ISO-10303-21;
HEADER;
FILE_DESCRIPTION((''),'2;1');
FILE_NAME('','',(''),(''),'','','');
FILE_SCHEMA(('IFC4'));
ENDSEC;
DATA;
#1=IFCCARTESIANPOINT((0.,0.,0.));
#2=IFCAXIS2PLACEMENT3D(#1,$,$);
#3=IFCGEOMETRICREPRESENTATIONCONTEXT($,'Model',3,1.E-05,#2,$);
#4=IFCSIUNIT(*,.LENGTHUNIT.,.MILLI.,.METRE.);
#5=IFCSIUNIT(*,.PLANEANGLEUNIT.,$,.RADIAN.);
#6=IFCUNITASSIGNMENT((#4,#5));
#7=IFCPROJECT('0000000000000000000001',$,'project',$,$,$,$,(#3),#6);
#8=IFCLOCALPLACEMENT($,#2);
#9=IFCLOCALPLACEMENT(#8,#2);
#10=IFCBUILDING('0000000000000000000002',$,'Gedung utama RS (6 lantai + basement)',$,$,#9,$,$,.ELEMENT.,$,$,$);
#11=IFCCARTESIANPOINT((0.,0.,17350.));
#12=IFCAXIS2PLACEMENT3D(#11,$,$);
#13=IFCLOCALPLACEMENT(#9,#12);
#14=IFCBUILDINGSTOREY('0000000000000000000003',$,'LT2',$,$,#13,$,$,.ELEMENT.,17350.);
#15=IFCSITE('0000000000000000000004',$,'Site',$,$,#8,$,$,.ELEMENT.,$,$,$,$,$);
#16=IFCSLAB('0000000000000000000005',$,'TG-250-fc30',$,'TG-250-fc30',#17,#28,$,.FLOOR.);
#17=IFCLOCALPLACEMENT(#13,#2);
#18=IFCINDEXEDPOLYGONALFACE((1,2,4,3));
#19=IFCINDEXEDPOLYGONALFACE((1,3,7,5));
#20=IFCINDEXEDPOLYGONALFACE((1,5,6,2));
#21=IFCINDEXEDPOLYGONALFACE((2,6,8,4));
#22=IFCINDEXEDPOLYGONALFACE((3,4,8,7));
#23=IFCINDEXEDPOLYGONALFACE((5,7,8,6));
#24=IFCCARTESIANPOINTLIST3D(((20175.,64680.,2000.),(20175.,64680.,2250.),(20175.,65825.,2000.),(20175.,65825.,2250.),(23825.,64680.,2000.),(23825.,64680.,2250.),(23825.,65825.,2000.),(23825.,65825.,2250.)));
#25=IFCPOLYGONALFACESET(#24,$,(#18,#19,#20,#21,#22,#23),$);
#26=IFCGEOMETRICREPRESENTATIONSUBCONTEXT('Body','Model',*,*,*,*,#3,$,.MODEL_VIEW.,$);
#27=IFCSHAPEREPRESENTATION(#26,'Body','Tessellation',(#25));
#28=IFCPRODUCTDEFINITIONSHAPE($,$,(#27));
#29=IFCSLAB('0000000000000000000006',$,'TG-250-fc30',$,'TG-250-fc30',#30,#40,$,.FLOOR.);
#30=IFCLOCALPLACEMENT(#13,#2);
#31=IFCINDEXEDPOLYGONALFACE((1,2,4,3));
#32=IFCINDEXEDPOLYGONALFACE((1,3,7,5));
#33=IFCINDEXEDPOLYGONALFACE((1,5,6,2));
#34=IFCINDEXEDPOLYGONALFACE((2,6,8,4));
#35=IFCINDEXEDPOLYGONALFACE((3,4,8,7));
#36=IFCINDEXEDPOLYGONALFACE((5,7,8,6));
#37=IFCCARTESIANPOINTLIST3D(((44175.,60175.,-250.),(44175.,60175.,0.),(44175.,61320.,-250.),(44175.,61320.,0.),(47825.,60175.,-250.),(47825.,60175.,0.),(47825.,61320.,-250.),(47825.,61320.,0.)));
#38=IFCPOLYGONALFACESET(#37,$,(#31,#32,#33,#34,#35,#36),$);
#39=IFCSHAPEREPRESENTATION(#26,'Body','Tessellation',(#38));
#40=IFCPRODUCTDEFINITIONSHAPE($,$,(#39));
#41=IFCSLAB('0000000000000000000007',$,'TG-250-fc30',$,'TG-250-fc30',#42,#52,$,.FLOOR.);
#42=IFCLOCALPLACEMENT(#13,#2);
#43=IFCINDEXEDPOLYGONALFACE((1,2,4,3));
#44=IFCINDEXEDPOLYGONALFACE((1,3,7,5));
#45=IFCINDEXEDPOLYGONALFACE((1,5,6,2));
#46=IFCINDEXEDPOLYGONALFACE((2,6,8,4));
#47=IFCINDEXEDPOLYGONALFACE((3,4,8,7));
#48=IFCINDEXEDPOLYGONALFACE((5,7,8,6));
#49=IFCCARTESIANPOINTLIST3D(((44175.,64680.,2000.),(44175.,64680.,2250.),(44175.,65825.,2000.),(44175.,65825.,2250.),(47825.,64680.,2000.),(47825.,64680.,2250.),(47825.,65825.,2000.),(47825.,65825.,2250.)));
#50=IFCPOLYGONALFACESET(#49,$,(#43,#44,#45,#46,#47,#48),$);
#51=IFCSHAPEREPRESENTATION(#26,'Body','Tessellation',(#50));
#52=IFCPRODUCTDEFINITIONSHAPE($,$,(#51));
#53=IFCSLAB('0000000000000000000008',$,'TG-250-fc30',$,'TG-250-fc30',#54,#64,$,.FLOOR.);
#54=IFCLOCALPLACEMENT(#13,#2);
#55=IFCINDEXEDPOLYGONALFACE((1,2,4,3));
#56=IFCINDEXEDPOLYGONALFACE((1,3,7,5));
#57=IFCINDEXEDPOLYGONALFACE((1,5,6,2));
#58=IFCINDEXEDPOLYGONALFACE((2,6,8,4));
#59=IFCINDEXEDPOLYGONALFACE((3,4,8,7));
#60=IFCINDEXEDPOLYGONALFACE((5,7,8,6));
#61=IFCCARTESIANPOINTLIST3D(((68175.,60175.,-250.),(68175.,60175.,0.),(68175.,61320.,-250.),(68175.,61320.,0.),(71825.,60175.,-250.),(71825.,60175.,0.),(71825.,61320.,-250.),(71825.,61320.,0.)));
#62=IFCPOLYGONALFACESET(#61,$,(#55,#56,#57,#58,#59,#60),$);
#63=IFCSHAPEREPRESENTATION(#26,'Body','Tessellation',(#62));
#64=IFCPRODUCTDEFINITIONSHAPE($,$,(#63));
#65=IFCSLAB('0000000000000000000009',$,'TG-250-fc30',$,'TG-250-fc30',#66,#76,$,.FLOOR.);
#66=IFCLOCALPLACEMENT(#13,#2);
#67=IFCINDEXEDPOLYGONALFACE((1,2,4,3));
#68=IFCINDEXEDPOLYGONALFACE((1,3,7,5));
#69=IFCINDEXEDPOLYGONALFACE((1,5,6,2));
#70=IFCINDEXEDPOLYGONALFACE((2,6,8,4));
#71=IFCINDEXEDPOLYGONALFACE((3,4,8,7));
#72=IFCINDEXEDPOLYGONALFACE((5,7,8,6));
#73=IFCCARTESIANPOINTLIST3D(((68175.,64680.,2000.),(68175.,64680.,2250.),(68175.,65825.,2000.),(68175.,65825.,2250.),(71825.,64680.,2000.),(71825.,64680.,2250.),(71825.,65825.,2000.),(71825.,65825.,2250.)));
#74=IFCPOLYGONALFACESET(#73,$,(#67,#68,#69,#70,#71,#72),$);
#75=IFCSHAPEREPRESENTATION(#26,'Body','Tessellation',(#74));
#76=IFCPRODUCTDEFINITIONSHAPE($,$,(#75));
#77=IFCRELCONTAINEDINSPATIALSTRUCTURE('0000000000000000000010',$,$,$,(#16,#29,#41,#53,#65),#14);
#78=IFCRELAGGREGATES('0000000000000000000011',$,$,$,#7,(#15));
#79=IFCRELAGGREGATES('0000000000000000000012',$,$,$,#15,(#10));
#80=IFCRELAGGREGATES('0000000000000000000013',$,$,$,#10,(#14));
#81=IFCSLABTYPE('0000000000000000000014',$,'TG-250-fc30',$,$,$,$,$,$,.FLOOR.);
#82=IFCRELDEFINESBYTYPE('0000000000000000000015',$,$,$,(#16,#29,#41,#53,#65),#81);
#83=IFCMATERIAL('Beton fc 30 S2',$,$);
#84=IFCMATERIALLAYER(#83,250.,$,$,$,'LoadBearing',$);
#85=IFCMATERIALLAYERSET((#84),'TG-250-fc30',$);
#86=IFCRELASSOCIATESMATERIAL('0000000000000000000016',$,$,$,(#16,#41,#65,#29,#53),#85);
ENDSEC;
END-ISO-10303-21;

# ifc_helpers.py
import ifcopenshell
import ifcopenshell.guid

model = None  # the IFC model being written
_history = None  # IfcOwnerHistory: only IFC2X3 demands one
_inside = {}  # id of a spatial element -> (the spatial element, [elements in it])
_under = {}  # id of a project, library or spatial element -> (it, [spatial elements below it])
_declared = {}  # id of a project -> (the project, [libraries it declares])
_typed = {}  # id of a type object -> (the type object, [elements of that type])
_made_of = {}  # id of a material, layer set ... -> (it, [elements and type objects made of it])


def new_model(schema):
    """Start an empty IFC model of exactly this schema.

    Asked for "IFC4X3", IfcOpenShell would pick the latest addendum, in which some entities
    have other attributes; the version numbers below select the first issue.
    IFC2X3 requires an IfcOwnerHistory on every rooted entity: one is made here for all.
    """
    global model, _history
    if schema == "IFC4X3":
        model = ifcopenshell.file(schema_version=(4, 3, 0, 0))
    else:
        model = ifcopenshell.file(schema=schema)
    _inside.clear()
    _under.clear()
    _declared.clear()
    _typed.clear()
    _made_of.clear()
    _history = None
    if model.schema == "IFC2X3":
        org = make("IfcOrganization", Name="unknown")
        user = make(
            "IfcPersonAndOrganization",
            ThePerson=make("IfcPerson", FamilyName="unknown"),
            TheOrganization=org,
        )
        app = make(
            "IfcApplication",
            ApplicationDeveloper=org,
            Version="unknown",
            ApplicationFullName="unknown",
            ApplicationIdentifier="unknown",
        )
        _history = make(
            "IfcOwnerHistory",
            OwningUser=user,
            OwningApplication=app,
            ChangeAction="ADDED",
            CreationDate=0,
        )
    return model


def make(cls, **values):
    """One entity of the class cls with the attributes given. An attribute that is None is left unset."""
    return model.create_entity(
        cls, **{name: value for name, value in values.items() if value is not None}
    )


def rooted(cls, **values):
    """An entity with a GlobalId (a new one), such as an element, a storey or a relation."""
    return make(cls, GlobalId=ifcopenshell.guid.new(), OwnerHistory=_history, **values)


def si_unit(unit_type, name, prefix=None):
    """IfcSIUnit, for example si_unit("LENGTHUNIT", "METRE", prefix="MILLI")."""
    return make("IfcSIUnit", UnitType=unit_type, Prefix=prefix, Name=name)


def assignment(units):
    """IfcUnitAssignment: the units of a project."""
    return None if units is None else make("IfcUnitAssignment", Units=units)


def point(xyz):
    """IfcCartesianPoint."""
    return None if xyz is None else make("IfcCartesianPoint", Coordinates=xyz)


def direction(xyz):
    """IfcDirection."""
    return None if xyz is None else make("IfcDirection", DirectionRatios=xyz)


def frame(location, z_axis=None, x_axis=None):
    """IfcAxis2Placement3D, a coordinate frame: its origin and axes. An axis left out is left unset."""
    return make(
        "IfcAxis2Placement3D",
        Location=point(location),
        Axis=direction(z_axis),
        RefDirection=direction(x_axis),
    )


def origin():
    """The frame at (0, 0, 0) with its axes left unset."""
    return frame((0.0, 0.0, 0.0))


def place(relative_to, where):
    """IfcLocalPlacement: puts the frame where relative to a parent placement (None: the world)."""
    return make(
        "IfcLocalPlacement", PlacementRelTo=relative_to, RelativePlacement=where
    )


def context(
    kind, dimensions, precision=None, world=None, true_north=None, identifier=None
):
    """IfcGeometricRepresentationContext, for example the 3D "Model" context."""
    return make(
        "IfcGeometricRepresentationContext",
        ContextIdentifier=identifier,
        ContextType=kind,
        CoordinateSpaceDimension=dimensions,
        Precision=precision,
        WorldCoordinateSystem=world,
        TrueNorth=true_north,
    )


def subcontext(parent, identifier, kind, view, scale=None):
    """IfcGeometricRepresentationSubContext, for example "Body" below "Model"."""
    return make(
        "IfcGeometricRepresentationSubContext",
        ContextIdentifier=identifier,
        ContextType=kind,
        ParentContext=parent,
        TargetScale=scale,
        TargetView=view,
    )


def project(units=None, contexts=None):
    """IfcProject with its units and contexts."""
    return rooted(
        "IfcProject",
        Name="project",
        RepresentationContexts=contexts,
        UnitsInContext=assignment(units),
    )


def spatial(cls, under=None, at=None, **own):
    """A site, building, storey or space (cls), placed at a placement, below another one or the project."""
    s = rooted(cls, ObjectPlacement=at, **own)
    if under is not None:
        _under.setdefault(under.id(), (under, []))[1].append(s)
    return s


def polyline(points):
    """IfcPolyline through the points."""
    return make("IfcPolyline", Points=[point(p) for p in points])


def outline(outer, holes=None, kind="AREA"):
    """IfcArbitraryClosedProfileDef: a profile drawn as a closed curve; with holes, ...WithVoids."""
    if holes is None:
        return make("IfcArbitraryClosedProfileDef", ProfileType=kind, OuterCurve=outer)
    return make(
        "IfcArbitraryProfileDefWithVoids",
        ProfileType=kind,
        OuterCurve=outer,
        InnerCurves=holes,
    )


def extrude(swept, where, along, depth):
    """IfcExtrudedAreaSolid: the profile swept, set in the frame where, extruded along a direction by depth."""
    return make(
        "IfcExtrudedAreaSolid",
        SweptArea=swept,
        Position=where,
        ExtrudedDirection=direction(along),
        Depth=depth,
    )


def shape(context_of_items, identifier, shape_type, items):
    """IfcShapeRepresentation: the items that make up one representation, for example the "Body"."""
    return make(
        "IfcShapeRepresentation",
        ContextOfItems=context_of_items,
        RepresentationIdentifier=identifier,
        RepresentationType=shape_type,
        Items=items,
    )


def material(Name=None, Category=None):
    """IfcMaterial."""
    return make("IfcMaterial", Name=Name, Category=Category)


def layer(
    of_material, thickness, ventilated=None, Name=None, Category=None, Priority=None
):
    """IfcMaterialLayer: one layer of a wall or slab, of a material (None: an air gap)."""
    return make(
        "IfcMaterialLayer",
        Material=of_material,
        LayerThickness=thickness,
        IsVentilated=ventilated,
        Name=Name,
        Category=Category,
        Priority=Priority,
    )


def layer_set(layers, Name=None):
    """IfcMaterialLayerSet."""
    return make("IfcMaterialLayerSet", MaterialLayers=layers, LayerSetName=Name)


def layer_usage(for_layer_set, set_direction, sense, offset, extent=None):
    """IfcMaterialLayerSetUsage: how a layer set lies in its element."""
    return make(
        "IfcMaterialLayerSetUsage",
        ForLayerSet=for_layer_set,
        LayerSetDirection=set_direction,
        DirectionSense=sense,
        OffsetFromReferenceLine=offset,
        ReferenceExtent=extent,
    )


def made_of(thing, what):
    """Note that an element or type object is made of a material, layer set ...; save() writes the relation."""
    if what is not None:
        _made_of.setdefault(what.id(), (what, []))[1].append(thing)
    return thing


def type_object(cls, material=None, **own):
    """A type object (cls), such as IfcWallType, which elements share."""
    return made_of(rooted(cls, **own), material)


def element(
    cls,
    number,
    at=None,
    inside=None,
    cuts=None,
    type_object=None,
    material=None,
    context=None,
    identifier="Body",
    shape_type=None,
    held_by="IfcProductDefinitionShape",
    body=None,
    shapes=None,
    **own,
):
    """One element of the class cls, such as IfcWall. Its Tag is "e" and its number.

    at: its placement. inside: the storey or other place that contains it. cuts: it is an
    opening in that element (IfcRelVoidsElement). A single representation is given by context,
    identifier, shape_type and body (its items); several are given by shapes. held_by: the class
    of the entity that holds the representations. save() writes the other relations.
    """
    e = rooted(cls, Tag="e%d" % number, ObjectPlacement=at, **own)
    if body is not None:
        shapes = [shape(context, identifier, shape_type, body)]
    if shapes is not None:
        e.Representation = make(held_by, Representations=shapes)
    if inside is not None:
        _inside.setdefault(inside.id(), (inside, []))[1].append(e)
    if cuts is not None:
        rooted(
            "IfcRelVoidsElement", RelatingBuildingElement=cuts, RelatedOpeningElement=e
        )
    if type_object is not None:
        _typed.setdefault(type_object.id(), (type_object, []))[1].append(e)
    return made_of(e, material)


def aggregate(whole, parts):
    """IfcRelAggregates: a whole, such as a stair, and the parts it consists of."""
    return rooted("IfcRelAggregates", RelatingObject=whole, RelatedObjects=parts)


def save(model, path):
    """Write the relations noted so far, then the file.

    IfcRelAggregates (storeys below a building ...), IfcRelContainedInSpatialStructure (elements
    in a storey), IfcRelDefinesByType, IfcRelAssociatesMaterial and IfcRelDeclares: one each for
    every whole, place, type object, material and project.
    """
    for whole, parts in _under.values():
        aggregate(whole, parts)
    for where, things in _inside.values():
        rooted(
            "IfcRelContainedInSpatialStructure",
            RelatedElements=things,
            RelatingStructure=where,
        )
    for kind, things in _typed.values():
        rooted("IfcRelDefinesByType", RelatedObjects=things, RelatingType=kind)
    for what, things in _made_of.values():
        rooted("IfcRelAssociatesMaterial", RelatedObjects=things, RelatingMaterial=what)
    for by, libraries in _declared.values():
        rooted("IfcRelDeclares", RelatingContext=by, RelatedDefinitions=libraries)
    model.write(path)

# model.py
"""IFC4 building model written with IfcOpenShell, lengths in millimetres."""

from ifc_helpers import new_model, si_unit, frame, origin, place, context, subcontext, project, spatial, polyline, outline, extrude, material, layer, layer_set, layer_usage, type_object, element, save


model = new_model("IFC4")

# Units and contexts
model_context = context("Model", 3, precision=1e-05, world=origin())
body_context = subcontext(model_context, "Body", "Model", "MODEL_VIEW")
ifc_project = project(units=[si_unit("LENGTHUNIT", "METRE", prefix="MILLI"), si_unit("PLANEANGLEUNIT", "RADIAN")], contexts=[model_context])

# Site, building, storey
site_placement = place(None, origin())
site = spatial("IfcSite", under=ifc_project, at=site_placement, Name="Site", CompositionType="ELEMENT")
building_placement = place(site_placement, origin())
building = spatial("IfcBuilding", under=site, at=building_placement, Name="Gedung utama RS (6 lantai + basement)", CompositionType="ELEMENT")
storey_placement = place(building_placement, frame((0.0, 0.0, 17350.0)))
storey = spatial("IfcBuildingStorey", under=building, at=storey_placement, Name="LT2", CompositionType="ELEMENT", Elevation=17350.0)

# Shared definitions
ifc_material = material(Name="Beton fc 30 S2")

# Slabs
ifc_layer_1 = layer(ifc_material, 250.0, Category="LoadBearing")
ifc_layer_set_1 = layer_set([ifc_layer_1], Name="TG-250-fc30")
ifc_layer_usage_1 = layer_usage(ifc_layer_set_1, "AXIS3", "NEGATIVE", 0.0)
slab_type_1 = type_object("IfcSlabType", Name="TG-250-fc30", PredefinedType="FLOOR")
ifc_layer_usage_2 = layer_usage(ifc_layer_set_1, "AXIS3", "NEGATIVE", 2250.0)
slab_1_placement = place(storey_placement, origin())
element("IfcSlab", 1, at=slab_1_placement, inside=storey, type_object=slab_type_1, material=ifc_layer_usage_2, Name="TG-250-fc30", ObjectType="TG-250-fc30", PredefinedType="FLOOR", context=body_context, shape_type="SweptSolid", body=[
    extrude(outline(polyline([(23825.0, 64680.0), (23825.0, 65825.0), (20175.0, 65825.0), (20175.0, 64680.0), (23825.0, 64680.0)])), frame((0.0, 0.0, 2000.0)), (0.0, 0.0, 1.0), 250.0),
])
slab_2_placement = place(storey_placement, origin())
element("IfcSlab", 2, at=slab_2_placement, inside=storey, type_object=slab_type_1, material=ifc_layer_usage_1, Name="TG-250-fc30", ObjectType="TG-250-fc30", PredefinedType="FLOOR", context=body_context, shape_type="SweptSolid", body=[
    extrude(outline(polyline([(47825.0, 60175.0), (47825.0, 61320.0), (44175.0, 61320.0), (44175.0, 60175.0), (47825.0, 60175.0)])), frame((0.0, 0.0, -250.0)), (0.0, 0.0, 1.0), 250.0),
])
slab_3_placement = place(storey_placement, origin())
element("IfcSlab", 3, at=slab_3_placement, inside=storey, type_object=slab_type_1, material=ifc_layer_usage_2, Name="TG-250-fc30", ObjectType="TG-250-fc30", PredefinedType="FLOOR", context=body_context, shape_type="SweptSolid", body=[
    extrude(outline(polyline([(47825.0, 64680.0), (47825.0, 65825.0), (44175.0, 65825.0), (44175.0, 64680.0), (47825.0, 64680.0)])), frame((0.0, 0.0, 2000.0)), (0.0, 0.0, 1.0), 250.0),
])
slab_4_placement = place(storey_placement, origin())
element("IfcSlab", 4, at=slab_4_placement, inside=storey, type_object=slab_type_1, material=ifc_layer_usage_1, Name="TG-250-fc30", ObjectType="TG-250-fc30", PredefinedType="FLOOR", context=body_context, shape_type="SweptSolid", body=[
    extrude(outline(polyline([(71825.0, 60175.0), (71825.0, 61320.0), (68175.0, 61320.0), (68175.0, 60175.0), (71825.0, 60175.0)])), frame((0.0, 0.0, -250.0)), (0.0, 0.0, 1.0), 250.0),
])
slab_5_placement = place(storey_placement, origin())
element("IfcSlab", 5, at=slab_5_placement, inside=storey, type_object=slab_type_1, material=ifc_layer_usage_2, Name="TG-250-fc30", ObjectType="TG-250-fc30", PredefinedType="FLOOR", context=body_context, shape_type="SweptSolid", body=[
    extrude(outline(polyline([(71825.0, 64680.0), (71825.0, 65825.0), (68175.0, 65825.0), (68175.0, 64680.0), (71825.0, 64680.0)])), frame((0.0, 0.0, 2000.0)), (0.0, 0.0, 1.0), 250.0),
])

save(model, "model.ifc")
